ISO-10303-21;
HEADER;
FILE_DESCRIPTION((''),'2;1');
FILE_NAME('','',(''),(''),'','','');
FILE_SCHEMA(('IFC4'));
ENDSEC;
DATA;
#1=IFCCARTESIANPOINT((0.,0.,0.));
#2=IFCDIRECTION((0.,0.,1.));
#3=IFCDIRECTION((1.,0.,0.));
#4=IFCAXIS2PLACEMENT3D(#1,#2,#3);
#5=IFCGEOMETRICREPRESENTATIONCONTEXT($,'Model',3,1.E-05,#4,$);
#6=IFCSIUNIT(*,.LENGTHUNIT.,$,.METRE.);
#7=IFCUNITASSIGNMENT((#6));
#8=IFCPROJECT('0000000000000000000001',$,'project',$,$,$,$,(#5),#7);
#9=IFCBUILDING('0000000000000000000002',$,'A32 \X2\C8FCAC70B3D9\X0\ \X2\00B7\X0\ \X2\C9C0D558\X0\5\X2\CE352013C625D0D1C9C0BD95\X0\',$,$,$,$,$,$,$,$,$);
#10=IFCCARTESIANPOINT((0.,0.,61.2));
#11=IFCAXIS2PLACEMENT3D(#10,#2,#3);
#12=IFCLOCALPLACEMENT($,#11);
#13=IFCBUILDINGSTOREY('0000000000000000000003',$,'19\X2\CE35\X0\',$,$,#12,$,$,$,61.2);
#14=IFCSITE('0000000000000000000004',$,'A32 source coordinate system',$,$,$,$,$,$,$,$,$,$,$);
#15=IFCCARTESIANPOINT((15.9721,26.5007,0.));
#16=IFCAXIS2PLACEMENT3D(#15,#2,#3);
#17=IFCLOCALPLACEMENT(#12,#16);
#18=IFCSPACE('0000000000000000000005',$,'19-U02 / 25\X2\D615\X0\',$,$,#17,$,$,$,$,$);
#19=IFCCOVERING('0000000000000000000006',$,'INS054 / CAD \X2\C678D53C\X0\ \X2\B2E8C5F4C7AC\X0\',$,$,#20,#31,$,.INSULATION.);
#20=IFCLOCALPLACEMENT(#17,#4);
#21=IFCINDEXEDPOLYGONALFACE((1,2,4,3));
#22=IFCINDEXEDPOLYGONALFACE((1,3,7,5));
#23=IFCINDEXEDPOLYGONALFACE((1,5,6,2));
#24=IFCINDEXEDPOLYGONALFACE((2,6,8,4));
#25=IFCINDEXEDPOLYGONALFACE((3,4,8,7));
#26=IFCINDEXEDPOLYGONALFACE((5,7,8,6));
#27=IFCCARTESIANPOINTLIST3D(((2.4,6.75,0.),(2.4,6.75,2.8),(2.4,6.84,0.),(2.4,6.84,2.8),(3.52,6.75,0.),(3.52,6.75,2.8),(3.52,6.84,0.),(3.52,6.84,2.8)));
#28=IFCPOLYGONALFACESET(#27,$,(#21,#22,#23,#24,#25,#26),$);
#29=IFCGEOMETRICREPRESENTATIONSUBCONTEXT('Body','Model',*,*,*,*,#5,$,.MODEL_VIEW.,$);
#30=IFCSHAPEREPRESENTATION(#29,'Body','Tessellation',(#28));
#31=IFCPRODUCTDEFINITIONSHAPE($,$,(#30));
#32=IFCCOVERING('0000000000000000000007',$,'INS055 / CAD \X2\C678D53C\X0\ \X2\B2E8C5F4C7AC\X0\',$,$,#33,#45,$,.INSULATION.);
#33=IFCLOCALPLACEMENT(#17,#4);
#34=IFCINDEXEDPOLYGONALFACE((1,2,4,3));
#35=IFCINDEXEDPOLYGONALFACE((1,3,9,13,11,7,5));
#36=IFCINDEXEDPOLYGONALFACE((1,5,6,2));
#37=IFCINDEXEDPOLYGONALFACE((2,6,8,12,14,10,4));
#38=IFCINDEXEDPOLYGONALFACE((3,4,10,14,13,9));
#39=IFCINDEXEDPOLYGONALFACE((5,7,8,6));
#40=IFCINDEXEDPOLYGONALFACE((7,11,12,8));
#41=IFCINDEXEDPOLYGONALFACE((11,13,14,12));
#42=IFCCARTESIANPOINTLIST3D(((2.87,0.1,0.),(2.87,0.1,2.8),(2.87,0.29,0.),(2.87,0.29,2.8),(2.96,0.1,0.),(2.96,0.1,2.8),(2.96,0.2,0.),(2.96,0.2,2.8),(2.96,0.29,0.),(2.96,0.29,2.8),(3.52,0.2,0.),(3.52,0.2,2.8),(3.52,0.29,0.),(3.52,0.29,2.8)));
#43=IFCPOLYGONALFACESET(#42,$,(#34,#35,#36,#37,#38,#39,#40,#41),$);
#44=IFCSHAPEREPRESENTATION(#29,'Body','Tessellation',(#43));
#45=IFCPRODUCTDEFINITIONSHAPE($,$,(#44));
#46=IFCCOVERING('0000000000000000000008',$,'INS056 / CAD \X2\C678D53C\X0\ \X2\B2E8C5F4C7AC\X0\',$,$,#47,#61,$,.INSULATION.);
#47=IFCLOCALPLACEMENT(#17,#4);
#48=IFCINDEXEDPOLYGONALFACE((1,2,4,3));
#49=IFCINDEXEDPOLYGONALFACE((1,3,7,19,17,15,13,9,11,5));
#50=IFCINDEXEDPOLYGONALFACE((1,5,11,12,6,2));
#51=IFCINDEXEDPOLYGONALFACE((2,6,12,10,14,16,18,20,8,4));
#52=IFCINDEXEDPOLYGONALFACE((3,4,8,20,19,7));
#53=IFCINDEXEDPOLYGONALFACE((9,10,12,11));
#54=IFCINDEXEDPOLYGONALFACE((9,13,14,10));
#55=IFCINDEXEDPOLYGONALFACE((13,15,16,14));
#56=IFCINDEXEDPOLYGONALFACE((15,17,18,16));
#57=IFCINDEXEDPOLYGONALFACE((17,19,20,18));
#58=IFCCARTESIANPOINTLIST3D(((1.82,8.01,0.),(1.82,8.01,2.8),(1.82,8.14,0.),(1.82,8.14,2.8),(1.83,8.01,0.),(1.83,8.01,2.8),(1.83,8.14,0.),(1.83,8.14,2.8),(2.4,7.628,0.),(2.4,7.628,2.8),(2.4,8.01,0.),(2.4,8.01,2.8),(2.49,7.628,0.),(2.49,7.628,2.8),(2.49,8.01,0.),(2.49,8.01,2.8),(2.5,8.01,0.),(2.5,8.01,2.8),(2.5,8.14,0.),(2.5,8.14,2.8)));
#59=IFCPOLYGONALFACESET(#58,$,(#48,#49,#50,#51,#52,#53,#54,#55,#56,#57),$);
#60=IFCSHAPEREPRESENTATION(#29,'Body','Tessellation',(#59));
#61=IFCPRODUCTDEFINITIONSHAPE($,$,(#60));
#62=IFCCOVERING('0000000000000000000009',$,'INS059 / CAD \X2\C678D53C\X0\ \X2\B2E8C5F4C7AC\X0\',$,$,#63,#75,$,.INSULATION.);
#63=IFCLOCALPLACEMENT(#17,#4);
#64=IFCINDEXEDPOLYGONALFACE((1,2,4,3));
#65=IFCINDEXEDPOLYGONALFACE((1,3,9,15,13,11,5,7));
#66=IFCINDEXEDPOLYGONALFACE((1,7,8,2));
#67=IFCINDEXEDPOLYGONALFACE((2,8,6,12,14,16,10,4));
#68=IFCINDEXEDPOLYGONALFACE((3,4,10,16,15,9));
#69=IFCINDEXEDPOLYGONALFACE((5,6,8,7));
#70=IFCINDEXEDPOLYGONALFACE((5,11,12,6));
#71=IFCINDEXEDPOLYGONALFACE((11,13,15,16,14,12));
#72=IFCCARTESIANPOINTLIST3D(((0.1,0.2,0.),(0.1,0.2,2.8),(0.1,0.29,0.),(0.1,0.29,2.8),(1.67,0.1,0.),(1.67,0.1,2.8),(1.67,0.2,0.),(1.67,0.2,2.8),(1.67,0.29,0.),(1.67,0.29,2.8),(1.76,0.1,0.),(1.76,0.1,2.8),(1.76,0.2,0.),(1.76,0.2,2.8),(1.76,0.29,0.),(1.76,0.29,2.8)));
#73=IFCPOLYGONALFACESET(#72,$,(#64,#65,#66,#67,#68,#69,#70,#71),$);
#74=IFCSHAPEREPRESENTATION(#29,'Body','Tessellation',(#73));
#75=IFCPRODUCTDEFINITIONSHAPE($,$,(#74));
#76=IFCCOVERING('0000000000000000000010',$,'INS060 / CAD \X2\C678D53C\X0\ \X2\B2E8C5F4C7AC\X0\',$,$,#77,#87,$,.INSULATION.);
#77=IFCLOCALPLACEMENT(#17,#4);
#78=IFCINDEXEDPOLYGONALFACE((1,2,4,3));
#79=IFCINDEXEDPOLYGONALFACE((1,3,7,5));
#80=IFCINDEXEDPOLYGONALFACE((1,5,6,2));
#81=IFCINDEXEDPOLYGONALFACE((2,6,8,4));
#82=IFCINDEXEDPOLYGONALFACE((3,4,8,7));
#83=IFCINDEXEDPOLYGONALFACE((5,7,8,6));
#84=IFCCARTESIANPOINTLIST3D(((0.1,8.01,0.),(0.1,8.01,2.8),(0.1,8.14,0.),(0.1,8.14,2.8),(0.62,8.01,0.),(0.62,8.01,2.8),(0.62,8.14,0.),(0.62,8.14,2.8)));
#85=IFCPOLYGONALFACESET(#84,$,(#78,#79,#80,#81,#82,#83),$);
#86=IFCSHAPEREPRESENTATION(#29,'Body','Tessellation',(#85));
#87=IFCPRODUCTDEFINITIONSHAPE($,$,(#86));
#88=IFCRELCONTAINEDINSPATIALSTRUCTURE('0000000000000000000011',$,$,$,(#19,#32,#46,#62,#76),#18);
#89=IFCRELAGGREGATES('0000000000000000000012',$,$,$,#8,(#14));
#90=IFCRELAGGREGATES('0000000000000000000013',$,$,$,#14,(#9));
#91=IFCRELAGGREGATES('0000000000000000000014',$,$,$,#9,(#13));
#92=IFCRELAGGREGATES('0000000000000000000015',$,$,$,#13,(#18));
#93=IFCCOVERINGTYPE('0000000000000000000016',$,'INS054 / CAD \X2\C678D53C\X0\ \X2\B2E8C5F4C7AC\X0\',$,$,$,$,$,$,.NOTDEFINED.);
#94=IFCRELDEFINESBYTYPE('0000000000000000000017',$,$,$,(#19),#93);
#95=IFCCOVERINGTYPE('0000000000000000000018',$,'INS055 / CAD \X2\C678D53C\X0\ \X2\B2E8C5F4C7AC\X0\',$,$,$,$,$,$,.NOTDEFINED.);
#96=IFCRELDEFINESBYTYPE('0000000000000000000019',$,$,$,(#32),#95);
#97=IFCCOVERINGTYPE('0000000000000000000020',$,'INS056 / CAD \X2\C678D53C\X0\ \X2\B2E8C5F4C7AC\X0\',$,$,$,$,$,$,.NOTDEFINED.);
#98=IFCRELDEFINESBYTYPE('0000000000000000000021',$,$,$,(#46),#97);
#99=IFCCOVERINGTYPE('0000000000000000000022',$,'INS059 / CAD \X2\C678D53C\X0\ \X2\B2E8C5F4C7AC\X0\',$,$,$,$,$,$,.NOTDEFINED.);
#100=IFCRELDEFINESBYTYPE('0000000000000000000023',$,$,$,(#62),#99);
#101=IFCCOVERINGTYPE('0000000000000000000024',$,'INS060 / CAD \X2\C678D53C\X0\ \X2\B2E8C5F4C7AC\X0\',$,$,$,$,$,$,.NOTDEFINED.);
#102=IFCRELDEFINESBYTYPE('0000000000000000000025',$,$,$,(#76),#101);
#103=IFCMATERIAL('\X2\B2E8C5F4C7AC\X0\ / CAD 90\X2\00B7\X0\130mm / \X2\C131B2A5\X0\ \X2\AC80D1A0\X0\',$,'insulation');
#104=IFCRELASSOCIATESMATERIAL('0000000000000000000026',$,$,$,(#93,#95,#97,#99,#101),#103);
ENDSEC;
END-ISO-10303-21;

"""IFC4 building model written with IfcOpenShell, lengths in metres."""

from ifc_helpers import new_model, si_unit, frame, origin, origin_with_axes, place, context, subcontext, project, spatial, polyline, outline, extrude, source, transform, mapped, material, type_object, type_shapes, element, save


model = new_model("IFC4")

# Units and contexts
model_context = context("Model", 3, precision=1e-05, world=origin_with_axes())
body_context = subcontext(model_context, "Body", "Model", "MODEL_VIEW")
ifc_project = project(units=[si_unit("LENGTHUNIT", "METRE")], contexts=[model_context])

# Site, building, storey, space
storey_placement = place(None, frame((0.0, 0.0, 61.2), z_axis=(0.0, 0.0, 1.0), x_axis=(1.0, 0.0, 0.0)))
space_placement = place(storey_placement, frame((15.9721, 26.5007, 0.0), z_axis=(0.0, 0.0, 1.0), x_axis=(1.0, 0.0, 0.0)))
site = spatial("IfcSite", under=ifc_project, Name="A32 source coordinate system")
building = spatial("IfcBuilding", under=site, Name="A32 주거동 · 지하5층–옥탑지붕")
storey = spatial("IfcBuildingStorey", under=building, at=storey_placement, Name="19층", Elevation=61.2)
space = spatial("IfcSpace", under=storey, at=space_placement, Name="19-U02 / 25형")

# Coverings
ifc_material = material(Name="단열재 / CAD 90·130mm / 성능 검토", Category="insulation")
covering_type_1 = type_object("IfcCoveringType", Name="INS054 / CAD 외피 단열재", PredefinedType="NOTDEFINED", material=ifc_material)
shared_shape_1 = source(origin(), body_context, "Body", "SweptSolid", [
    extrude(outline(polyline([(2.4, 6.84), (3.52, 6.84), (3.52, 6.75), (2.4, 6.75), (2.4, 6.84)])), origin(), (0.0, 0.0, 1.0), 2.8),
])
type_shapes(covering_type_1, [shared_shape_1])
covering_1_placement = place(space_placement, origin_with_axes())
element("IfcCovering", 1, at=covering_1_placement, inside=space, type_object=covering_type_1, Name="INS054 / CAD 외피 단열재", PredefinedType="INSULATION", context=body_context, shape_type="MappedRepresentation", body=[
    mapped(shared_shape_1, transform((0.0, 0.0, 0.0), scale=1.0)),
])
covering_type_2 = type_object("IfcCoveringType", Name="INS055 / CAD 외피 단열재", PredefinedType="NOTDEFINED", material=ifc_material)
shared_shape_2 = source(origin(), body_context, "Body", "SweptSolid", [
    extrude(outline(polyline([(2.87, 0.29), (2.96, 0.29), (3.52, 0.29), (3.52, 0.2), (2.96, 0.2), (2.96, 0.1), (2.87, 0.1), (2.87, 0.29)])), origin(), (0.0, 0.0, 1.0), 2.8),
])
type_shapes(covering_type_2, [shared_shape_2])
covering_2_placement = place(space_placement, origin_with_axes())
element("IfcCovering", 2, at=covering_2_placement, inside=space, type_object=covering_type_2, Name="INS055 / CAD 외피 단열재", PredefinedType="INSULATION", context=body_context, shape_type="MappedRepresentation", body=[
    mapped(shared_shape_2, transform((0.0, 0.0, 0.0), scale=1.0)),
])
covering_type_3 = type_object("IfcCoveringType", Name="INS056 / CAD 외피 단열재", PredefinedType="NOTDEFINED", material=ifc_material)
shared_shape_3 = source(origin(), body_context, "Body", "SweptSolid", [
    extrude(outline(polyline([(2.49, 7.628), (2.4, 7.628), (2.4, 8.01), (1.83, 8.01), (1.82, 8.01), (1.82, 8.14), (1.83, 8.14), (2.5, 8.14), (2.5, 8.01), (2.49, 8.01), (2.49, 7.628)])), origin(), (0.0, 0.0, 1.0), 2.8),
])
type_shapes(covering_type_3, [shared_shape_3])
covering_3_placement = place(space_placement, origin_with_axes())
element("IfcCovering", 3, at=covering_3_placement, inside=space, type_object=covering_type_3, Name="INS056 / CAD 외피 단열재", PredefinedType="INSULATION", context=body_context, shape_type="MappedRepresentation", body=[
    mapped(shared_shape_3, transform((0.0, 0.0, 0.0), scale=1.0)),
])
covering_type_4 = type_object("IfcCoveringType", Name="INS059 / CAD 외피 단열재", PredefinedType="NOTDEFINED", material=ifc_material)
shared_shape_4 = source(origin(), body_context, "Body", "SweptSolid", [
    extrude(outline(polyline([(1.76, 0.1), (1.67, 0.1), (1.67, 0.2), (0.1, 0.2), (0.1, 0.29), (1.67, 0.29), (1.76, 0.29), (1.76, 0.2), (1.76, 0.1)])), origin(), (0.0, 0.0, 1.0), 2.8),
])
type_shapes(covering_type_4, [shared_shape_4])
covering_4_placement = place(space_placement, origin_with_axes())
element("IfcCovering", 4, at=covering_4_placement, inside=space, type_object=covering_type_4, Name="INS059 / CAD 외피 단열재", PredefinedType="INSULATION", context=body_context, shape_type="MappedRepresentation", body=[
    mapped(shared_shape_4, transform((0.0, 0.0, 0.0), scale=1.0)),
])
covering_type_5 = type_object("IfcCoveringType", Name="INS060 / CAD 외피 단열재", PredefinedType="NOTDEFINED", material=ifc_material)
shared_shape_5 = source(origin(), body_context, "Body", "SweptSolid", [
    extrude(outline(polyline([(0.1, 8.01), (0.1, 8.14), (0.62, 8.14), (0.62, 8.01), (0.1, 8.01)])), origin(), (0.0, 0.0, 1.0), 2.8),
])
type_shapes(covering_type_5, [shared_shape_5])
covering_5_placement = place(space_placement, origin_with_axes())
element("IfcCovering", 5, at=covering_5_placement, inside=space, type_object=covering_type_5, Name="INS060 / CAD 외피 단열재", PredefinedType="INSULATION", context=body_context, shape_type="MappedRepresentation", body=[
    mapped(shared_shape_5, transform((0.0, 0.0, 0.0), scale=1.0)),
])

save(model, "model.ifc")
